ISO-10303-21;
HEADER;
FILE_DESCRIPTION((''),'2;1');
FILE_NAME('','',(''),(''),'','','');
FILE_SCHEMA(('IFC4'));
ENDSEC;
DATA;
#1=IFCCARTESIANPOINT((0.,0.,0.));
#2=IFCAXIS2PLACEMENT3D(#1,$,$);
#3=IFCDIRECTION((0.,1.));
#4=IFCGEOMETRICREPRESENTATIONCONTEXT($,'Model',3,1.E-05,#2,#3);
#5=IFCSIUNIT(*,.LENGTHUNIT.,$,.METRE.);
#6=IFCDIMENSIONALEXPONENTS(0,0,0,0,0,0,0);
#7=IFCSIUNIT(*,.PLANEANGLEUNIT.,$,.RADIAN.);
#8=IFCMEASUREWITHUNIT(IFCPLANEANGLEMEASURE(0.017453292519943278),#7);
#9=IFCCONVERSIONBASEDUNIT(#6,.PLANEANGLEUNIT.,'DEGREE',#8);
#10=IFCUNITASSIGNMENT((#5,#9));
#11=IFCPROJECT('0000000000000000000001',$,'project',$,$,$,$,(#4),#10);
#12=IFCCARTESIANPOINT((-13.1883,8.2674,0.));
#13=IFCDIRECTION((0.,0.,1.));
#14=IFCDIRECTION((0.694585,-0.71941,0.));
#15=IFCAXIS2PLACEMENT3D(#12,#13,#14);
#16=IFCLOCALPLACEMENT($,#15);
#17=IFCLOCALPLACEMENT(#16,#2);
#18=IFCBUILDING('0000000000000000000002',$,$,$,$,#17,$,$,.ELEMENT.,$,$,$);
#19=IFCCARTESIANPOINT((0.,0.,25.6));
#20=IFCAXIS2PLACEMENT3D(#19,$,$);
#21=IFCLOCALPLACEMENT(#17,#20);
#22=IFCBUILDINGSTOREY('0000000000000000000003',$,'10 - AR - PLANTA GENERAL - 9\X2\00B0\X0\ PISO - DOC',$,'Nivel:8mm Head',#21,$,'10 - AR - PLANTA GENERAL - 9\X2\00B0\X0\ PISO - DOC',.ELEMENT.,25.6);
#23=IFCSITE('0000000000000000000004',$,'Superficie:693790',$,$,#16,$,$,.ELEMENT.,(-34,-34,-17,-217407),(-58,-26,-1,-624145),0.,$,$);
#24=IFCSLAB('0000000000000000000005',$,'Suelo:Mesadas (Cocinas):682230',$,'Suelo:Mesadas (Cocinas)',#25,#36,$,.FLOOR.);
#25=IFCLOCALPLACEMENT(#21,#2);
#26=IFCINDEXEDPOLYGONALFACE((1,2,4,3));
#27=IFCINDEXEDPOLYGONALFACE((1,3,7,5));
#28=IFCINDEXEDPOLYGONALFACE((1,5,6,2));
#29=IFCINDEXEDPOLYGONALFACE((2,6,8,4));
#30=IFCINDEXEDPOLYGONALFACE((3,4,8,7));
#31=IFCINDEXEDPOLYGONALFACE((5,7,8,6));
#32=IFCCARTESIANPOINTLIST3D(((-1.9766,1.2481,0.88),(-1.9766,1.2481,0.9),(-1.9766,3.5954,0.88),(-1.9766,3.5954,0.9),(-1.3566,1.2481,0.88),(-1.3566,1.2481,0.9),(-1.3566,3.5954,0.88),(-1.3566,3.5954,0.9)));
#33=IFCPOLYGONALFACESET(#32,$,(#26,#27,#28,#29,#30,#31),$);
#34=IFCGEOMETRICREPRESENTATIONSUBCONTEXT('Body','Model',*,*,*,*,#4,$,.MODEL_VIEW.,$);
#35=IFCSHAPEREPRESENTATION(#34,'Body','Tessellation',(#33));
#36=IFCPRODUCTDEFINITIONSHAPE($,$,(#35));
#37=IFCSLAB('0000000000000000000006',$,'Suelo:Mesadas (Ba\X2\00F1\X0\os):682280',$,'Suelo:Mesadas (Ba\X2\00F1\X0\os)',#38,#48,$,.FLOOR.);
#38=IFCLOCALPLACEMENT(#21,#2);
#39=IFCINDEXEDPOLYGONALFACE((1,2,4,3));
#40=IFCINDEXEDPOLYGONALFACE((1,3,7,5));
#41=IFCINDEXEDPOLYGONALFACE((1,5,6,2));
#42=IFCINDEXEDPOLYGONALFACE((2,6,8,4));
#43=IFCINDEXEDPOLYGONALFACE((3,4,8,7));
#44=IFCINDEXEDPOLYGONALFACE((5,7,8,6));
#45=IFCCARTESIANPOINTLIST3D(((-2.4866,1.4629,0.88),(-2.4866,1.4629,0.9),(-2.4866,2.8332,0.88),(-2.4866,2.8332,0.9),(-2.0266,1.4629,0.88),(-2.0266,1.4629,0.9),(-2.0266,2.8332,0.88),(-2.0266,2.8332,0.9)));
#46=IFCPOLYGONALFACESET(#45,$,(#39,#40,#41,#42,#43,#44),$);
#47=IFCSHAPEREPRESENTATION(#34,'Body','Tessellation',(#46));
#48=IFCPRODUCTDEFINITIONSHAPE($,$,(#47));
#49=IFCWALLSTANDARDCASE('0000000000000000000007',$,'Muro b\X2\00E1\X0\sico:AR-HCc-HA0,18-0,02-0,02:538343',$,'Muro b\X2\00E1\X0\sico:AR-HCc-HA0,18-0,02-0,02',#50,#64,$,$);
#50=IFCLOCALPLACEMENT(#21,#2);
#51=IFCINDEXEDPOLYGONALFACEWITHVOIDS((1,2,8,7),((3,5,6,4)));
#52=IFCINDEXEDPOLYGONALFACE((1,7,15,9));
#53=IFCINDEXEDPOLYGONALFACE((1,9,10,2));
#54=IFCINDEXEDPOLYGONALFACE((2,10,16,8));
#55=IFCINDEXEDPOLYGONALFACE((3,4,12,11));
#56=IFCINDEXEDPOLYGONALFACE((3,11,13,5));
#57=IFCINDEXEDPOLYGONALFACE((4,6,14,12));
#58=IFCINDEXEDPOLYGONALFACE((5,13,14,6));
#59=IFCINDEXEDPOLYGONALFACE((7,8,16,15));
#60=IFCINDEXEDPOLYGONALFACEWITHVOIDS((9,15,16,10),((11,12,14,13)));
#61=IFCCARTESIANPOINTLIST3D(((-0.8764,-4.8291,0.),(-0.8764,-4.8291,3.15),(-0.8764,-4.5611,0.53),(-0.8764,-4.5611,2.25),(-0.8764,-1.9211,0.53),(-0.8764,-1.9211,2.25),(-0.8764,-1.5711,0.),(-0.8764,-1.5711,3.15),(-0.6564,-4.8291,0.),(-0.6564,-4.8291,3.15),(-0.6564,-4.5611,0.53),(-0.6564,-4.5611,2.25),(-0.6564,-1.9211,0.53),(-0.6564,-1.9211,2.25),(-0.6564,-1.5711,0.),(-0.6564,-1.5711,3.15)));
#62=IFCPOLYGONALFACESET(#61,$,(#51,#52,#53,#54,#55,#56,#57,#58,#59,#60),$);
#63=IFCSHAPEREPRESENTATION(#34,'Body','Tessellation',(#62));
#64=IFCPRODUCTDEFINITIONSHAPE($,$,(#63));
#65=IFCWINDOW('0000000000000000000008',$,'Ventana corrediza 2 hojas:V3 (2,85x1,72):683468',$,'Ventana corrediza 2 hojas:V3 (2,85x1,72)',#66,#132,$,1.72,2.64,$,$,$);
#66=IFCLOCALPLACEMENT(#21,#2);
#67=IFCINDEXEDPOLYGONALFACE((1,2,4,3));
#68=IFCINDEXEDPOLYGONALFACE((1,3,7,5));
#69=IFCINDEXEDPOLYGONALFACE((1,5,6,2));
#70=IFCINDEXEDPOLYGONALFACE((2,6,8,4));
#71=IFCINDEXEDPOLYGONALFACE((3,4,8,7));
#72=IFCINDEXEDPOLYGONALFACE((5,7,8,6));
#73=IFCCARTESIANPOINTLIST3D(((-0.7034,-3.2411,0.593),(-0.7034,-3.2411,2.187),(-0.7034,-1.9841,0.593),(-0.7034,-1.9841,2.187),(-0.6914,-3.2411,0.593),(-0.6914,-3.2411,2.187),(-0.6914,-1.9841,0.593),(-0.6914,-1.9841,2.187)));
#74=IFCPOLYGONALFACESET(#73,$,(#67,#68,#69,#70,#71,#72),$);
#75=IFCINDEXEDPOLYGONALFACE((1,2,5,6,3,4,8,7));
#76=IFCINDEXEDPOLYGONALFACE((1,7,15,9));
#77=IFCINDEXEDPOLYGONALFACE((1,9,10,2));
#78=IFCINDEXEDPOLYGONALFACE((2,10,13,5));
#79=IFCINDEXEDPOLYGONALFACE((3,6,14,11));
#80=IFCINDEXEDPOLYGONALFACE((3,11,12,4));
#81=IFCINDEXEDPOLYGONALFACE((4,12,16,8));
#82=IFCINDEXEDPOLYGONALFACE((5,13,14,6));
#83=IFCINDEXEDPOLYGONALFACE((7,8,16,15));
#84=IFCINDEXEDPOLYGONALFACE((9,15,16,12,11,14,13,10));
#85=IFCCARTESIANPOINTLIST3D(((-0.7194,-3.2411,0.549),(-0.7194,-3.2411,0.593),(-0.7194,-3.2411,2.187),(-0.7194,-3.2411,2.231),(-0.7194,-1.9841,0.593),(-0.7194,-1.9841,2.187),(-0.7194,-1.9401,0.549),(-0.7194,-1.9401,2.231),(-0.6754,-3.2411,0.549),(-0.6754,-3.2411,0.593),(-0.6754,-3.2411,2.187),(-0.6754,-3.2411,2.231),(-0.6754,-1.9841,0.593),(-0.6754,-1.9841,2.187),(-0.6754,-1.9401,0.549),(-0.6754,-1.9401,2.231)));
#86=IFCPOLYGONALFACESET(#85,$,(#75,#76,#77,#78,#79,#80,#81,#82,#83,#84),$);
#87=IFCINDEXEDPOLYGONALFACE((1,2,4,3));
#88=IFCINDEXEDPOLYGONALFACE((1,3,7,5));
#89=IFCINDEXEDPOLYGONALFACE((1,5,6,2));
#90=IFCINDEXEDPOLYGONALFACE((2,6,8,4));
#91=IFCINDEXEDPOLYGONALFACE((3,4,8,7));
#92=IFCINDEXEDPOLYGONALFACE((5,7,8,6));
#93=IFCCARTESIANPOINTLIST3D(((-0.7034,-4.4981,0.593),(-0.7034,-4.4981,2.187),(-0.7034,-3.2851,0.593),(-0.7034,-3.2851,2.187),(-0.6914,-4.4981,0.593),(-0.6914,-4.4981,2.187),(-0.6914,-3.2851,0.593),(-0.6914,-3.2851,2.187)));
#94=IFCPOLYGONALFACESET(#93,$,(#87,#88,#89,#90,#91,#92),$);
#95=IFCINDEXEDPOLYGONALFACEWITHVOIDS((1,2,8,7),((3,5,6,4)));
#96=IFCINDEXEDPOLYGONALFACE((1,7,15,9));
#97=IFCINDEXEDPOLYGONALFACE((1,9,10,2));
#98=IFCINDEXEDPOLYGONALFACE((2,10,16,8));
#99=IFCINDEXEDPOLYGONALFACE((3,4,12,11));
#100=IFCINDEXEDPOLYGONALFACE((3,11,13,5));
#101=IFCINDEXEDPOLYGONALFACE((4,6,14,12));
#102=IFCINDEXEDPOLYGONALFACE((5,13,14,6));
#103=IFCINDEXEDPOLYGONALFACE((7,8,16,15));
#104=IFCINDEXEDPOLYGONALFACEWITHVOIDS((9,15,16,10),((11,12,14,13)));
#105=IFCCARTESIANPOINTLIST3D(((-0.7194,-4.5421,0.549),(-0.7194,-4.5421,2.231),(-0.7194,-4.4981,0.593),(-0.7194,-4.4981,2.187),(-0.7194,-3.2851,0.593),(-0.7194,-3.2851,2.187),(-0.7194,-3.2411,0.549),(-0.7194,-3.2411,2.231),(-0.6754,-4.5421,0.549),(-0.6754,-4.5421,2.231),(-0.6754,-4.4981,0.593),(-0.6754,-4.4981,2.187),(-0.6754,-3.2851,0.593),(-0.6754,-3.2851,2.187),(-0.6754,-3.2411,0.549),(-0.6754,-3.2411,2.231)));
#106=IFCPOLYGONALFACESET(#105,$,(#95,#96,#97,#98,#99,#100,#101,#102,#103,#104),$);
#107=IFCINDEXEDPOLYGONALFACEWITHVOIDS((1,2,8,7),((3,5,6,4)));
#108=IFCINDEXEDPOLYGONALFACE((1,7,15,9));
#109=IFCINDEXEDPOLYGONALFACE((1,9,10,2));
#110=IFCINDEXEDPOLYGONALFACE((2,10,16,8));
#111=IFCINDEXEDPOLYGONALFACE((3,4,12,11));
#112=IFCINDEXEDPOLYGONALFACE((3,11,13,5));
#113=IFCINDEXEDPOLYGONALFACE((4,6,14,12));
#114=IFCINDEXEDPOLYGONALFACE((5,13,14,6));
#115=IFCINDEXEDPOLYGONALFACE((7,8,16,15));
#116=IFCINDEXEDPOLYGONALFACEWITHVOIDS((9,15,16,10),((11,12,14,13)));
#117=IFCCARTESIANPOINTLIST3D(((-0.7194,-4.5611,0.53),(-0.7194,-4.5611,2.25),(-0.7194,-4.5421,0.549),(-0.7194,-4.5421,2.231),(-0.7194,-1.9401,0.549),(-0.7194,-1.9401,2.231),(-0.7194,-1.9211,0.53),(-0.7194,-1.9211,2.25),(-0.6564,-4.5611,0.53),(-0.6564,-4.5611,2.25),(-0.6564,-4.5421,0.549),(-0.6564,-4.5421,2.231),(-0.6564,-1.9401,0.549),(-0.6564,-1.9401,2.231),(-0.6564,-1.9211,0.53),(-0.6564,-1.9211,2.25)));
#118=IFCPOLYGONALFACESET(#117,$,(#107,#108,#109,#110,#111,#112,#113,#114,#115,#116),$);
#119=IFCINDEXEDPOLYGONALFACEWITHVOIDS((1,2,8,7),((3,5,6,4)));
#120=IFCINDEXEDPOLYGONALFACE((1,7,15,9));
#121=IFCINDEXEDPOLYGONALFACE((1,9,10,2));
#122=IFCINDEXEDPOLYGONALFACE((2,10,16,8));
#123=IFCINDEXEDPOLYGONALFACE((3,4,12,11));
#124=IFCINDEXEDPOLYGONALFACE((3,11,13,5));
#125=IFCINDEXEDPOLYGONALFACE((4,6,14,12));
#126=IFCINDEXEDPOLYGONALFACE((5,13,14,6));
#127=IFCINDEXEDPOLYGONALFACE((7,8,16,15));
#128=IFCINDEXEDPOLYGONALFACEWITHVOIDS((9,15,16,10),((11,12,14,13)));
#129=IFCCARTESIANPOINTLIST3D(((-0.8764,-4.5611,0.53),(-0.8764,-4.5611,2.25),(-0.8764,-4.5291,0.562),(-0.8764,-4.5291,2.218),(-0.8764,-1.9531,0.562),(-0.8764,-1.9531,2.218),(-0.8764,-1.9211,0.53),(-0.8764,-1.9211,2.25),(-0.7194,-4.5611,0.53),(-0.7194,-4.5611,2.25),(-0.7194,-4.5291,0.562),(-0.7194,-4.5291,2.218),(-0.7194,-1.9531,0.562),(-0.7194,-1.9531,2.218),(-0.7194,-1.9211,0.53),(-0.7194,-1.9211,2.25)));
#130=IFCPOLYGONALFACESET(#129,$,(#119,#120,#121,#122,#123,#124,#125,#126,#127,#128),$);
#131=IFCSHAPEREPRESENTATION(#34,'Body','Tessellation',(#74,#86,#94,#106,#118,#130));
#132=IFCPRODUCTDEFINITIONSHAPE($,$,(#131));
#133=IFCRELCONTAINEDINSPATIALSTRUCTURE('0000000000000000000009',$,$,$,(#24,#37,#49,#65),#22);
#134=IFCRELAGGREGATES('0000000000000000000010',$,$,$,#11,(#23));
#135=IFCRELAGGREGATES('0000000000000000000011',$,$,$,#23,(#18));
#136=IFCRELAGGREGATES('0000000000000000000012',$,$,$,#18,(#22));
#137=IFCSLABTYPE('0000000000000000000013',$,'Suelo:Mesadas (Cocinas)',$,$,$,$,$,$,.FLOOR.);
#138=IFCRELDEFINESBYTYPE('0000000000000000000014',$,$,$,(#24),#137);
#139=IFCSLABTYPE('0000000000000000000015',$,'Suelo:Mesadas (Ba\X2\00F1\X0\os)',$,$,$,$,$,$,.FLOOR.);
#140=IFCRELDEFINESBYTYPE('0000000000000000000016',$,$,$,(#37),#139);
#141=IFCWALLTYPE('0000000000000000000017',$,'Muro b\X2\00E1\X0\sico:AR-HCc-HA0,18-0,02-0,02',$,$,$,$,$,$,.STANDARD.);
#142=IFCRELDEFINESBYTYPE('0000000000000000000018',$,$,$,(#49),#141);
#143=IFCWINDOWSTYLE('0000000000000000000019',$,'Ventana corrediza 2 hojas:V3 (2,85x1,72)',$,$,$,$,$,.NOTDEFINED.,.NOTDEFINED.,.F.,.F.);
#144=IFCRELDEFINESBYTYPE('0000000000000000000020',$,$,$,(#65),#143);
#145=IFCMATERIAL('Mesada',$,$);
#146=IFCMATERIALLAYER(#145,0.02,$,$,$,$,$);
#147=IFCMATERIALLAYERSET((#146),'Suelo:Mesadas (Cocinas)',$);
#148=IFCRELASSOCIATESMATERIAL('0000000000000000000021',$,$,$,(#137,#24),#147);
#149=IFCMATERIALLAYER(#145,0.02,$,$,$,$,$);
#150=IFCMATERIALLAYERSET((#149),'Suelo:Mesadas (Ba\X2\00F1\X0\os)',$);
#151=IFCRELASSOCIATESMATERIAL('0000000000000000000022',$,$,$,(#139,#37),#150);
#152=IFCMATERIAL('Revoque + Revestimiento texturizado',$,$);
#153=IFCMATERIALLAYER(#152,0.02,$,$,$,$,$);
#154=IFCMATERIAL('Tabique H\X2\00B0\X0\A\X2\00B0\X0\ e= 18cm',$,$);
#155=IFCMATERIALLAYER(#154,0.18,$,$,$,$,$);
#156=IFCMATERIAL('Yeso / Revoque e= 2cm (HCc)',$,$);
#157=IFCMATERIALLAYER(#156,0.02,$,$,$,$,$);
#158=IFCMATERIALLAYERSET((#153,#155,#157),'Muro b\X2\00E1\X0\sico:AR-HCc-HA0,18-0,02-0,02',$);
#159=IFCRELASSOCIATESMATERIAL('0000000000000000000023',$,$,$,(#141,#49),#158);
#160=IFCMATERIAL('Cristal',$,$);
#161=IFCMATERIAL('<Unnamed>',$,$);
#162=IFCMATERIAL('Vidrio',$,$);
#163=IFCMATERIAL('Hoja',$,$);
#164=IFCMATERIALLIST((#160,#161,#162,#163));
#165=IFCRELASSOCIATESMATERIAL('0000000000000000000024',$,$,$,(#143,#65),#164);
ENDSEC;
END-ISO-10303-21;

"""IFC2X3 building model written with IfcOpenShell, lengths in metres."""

from ifc_helpers import new_model, entity, si_unit, converted_unit, direction, frame, frame_2d, origin, origin_2d_with_axis, place, context, subcontext, project, spatial, polyline, rectangle, outline, extrude, source, transform, mapped, material, material_list, layer, layer_set, layer_usage, type_object, type_shapes, element, fill, save


model = new_model("IFC2X3")

# Units and contexts
model_context = context("Model", 3, precision=1e-05, world=origin(), true_north=direction((0.0, 1.0)))
body_context = subcontext(model_context, "Body", "Model", "MODEL_VIEW")
ifc_project = project(units=[si_unit("LENGTHUNIT", "METRE"), converted_unit("PLANEANGLEUNIT", "DEGREE", entity("IfcPlaneAngleMeasure", 0.017453292519943278), si_unit("PLANEANGLEUNIT", "RADIAN"), dimensions=[0, 0, 0, 0, 0, 0, 0])], contexts=[model_context])

# Site, building, storey
site_placement = place(None, frame((-13.1883, 8.2674, 0.0), z_axis=(0.0, 0.0, 1.0), x_axis=(0.694585, -0.71941, 0.0)))
site = spatial("IfcSite", under=ifc_project, at=site_placement, Name="Superficie:693790", CompositionType="ELEMENT", RefLatitude=(-34, -34, -17, -217407), RefLongitude=(-58, -26, -1, -624145), RefElevation=0.0)
building_placement = place(site_placement, origin())
building = spatial("IfcBuilding", under=site, at=building_placement, CompositionType="ELEMENT")
storey_placement = place(building_placement, frame((0.0, 0.0, 25.6)))
storey = spatial("IfcBuildingStorey", under=building, at=storey_placement, Name="10 - AR - PLANTA GENERAL - 9° PISO - DOC", ObjectType="Nivel:8mm Head", LongName="10 - AR - PLANTA GENERAL - 9° PISO - DOC", CompositionType="ELEMENT", Elevation=25.6)

# Slabs
ifc_material_1 = material(Name="Mesada")
ifc_layer_1 = layer(ifc_material_1, 0.02)
ifc_layer_set_1 = layer_set([ifc_layer_1], Name="Suelo:Mesadas (Cocinas)")
ifc_layer_usage_1 = layer_usage(ifc_layer_set_1, "AXIS3", "POSITIVE", 0.0)
slab_type_1 = type_object("IfcSlabType", Name="Suelo:Mesadas (Cocinas)", PredefinedType="FLOOR", material=ifc_layer_set_1)
slab_1_placement = place(storey_placement, origin())
element("IfcSlab", 1, at=slab_1_placement, inside=storey, type_object=slab_type_1, material=ifc_layer_usage_1, Name="Suelo:Mesadas (Cocinas):682230", ObjectType="Suelo:Mesadas (Cocinas)", PredefinedType="FLOOR", context=body_context, shape_type="SweptSolid", body=[
    extrude(rectangle(XDim=2.3474, YDim=0.62, at=origin_2d_with_axis()), frame((-1.6666, 2.4217, 0.9), z_axis=(0.0, 0.0, -1.0), x_axis=(0.0, 1.0, 0.0)), (0.0, 0.0, 1.0), 0.02),
])
ifc_layer_2 = layer(ifc_material_1, 0.02)
ifc_layer_set_2 = layer_set([ifc_layer_2], Name="Suelo:Mesadas (Baños)")
ifc_layer_usage_2 = layer_usage(ifc_layer_set_2, "AXIS3", "POSITIVE", 0.0)
slab_type_2 = type_object("IfcSlabType", Name="Suelo:Mesadas (Baños)", PredefinedType="FLOOR", material=ifc_layer_set_2)
slab_2_placement = place(storey_placement, origin())
element("IfcSlab", 2, at=slab_2_placement, inside=storey, type_object=slab_type_2, material=ifc_layer_usage_2, Name="Suelo:Mesadas (Baños):682280", ObjectType="Suelo:Mesadas (Baños)", PredefinedType="FLOOR", context=body_context, shape_type="SweptSolid", body=[
    extrude(rectangle(XDim=1.3703, YDim=0.46, at=frame_2d((0.0, 0.0), x_axis=(1.0, 0.0))), frame((-2.2566, 2.1481, 0.9), z_axis=(0.0, 0.0, -1.0), x_axis=(0.0, 1.0, 0.0)), (0.0, 0.0, 1.0), 0.02),
])

# Wall, opening, window
ifc_material_2 = material(Name="Revoque + Revestimiento texturizado")
ifc_layer_3 = layer(ifc_material_2, 0.02)
ifc_material_3 = material(Name="Tabique H°A° e= 18cm")
ifc_layer_4 = layer(ifc_material_3, 0.18)
ifc_material_4 = material(Name="Yeso / Revoque e= 2cm (HCc)")
ifc_layer_5 = layer(ifc_material_4, 0.02)
ifc_layer_set_3 = layer_set([ifc_layer_3, ifc_layer_4, ifc_layer_5], Name="Muro básico:AR-HCc-HA0,18-0,02-0,02")
ifc_layer_usage_3 = layer_usage(ifc_layer_set_3, "AXIS2", "NEGATIVE", 0.11)
wall_type_1 = type_object("IfcWallType", Name="Muro básico:AR-HCc-HA0,18-0,02-0,02", PredefinedType="STANDARD", material=ifc_layer_set_3)
wall_1_placement = place(storey_placement, frame((-0.7664, -1.5711, 0.0), z_axis=(0.0, 0.0, 1.0), x_axis=(0.0, -1.0, 0.0)))
wall_1 = element("IfcWallStandardCase", 3, at=wall_1_placement, inside=storey, type_object=wall_type_1, material=ifc_layer_usage_3, Name="Muro básico:AR-HCc-HA0,18-0,02-0,02:538343", ObjectType="Muro básico:AR-HCc-HA0,18-0,02-0,02", context=body_context, shape_type="SweptSolid", body=[
    extrude(rectangle(XDim=3.258, YDim=0.22, at=frame_2d((1.629, 0.0), x_axis=(-1.0, 0.0))), origin(), (0.0, 0.0, 1.0), 3.15),
])
opening_1_placement = place(wall_1_placement, frame((0.35, -0.11, 0.53)))
opening_1 = element("IfcOpeningElement", 4, at=opening_1_placement, cuts=wall_1, ObjectType="Opening", context=body_context, shape_type="SweptSolid", body=[
    extrude(rectangle(XDim=1.72, YDim=2.64, at=frame_2d((0.86, 1.32), x_axis=(1.0, 0.0))), frame((0.0, 0.0, 0.0), z_axis=(0.0, 1.0, 0.0), x_axis=(0.0, 0.0, 1.0)), (0.0, 0.0, 1.0), 0.22),
])
ifc_material_5 = material(Name="Cristal")
ifc_material_6 = material(Name="<Unnamed>")
ifc_material_7 = material(Name="Vidrio")
ifc_material_8 = material(Name="Hoja")
ifc_material_list_1 = material_list([ifc_material_5, ifc_material_6, ifc_material_7, ifc_material_8])
window_style = type_object("IfcWindowStyle", Name="Ventana corrediza 2 hojas:V3 (2,85x1,72)", ConstructionType="NOTDEFINED", OperationType="NOTDEFINED", ParameterTakesPrecedence=False, Sizeable=False, material=ifc_material_list_1)
shared_shape_1 = source(origin(), body_context, "Body", "SweptSolid", [
    extrude(rectangle(XDim=0.012, YDim=1.257, at=frame_2d((0.0, 0.0), x_axis=(1.0, 0.0))), frame((0.6915, 0.179, 0.063), z_axis=(0.0, 0.0, 1.0), x_axis=(0.0, -1.0, 0.0)), (0.0, 0.0, 1.0), 1.594),
    extrude(outline(polyline([(-0.6615, -0.841), (0.6395, -0.841), (0.6395, -0.797), (-0.6175, -0.797), (-0.6175, 0.797), (0.6395, 0.797), (0.6395, 0.841), (-0.6615, 0.841), (-0.6615, -0.841)])), frame((0.6805, 0.157, 0.86), z_axis=(0.0, 1.0, 0.0), x_axis=(1.0, 0.0, 0.0)), (0.0, 0.0, 1.0), 0.044),
    extrude(rectangle(XDim=0.012, YDim=1.213, at=frame_2d((0.0, 0.0), x_axis=(1.0, 0.0))), frame((1.9705, 0.179, 0.063), z_axis=(0.0, 0.0, 1.0), x_axis=(0.0, -1.0, 0.0)), (0.0, 0.0, 1.0), 1.594),
    extrude(outline(polyline([(-0.6505, -0.841), (0.6505, -0.841), (0.6505, 0.841), (-0.6505, 0.841), (-0.6505, -0.841)]), holes=[polyline([(-0.6065, -0.797), (-0.6065, 0.797), (0.6065, 0.797), (0.6065, -0.797), (-0.6065, -0.797)])]), frame((1.9705, 0.157, 0.86), z_axis=(0.0, 1.0, 0.0), x_axis=(1.0, 0.0, 0.0)), (0.0, 0.0, 1.0), 0.044),
    extrude(outline(polyline([(-1.32, -0.86), (1.32, -0.86), (1.32, 0.86), (-1.32, 0.86), (-1.32, -0.86)]), holes=[polyline([(-1.301, -0.841), (-1.301, 0.841), (1.301, 0.841), (1.301, -0.841), (-1.301, -0.841)])]), frame((1.32, 0.157, 0.86), z_axis=(0.0, 1.0, 0.0), x_axis=(1.0, 0.0, 0.0)), (0.0, 0.0, 1.0), 0.063),
    extrude(outline(polyline([(-1.32, -0.86), (1.32, -0.86), (1.32, 0.86), (-1.32, 0.86), (-1.32, -0.86)]), holes=[polyline([(-1.288, -0.828), (-1.288, 0.828), (1.288, 0.828), (1.288, -0.828), (-1.288, -0.828)])]), frame((1.32, 0.0, 0.86), z_axis=(0.0, 1.0, 0.0), x_axis=(1.0, 0.0, 0.0)), (0.0, 0.0, 1.0), 0.157),
])
type_shapes(window_style, [shared_shape_1])
window_placement = place(opening_1_placement, origin())
window = element("IfcWindow", 5, at=window_placement, inside=storey, type_object=window_style, material=ifc_material_list_1, Name="Ventana corrediza 2 hojas:V3 (2,85x1,72):683468", ObjectType="Ventana corrediza 2 hojas:V3 (2,85x1,72)", OverallHeight=1.72, OverallWidth=2.64, context=body_context, shape_type="MappedRepresentation", body=[
    mapped(shared_shape_1, transform((0.0, 0.0, 0.0), scale=1.0)),
])
fill(opening_1, window)

save(model, "model.ifc")
